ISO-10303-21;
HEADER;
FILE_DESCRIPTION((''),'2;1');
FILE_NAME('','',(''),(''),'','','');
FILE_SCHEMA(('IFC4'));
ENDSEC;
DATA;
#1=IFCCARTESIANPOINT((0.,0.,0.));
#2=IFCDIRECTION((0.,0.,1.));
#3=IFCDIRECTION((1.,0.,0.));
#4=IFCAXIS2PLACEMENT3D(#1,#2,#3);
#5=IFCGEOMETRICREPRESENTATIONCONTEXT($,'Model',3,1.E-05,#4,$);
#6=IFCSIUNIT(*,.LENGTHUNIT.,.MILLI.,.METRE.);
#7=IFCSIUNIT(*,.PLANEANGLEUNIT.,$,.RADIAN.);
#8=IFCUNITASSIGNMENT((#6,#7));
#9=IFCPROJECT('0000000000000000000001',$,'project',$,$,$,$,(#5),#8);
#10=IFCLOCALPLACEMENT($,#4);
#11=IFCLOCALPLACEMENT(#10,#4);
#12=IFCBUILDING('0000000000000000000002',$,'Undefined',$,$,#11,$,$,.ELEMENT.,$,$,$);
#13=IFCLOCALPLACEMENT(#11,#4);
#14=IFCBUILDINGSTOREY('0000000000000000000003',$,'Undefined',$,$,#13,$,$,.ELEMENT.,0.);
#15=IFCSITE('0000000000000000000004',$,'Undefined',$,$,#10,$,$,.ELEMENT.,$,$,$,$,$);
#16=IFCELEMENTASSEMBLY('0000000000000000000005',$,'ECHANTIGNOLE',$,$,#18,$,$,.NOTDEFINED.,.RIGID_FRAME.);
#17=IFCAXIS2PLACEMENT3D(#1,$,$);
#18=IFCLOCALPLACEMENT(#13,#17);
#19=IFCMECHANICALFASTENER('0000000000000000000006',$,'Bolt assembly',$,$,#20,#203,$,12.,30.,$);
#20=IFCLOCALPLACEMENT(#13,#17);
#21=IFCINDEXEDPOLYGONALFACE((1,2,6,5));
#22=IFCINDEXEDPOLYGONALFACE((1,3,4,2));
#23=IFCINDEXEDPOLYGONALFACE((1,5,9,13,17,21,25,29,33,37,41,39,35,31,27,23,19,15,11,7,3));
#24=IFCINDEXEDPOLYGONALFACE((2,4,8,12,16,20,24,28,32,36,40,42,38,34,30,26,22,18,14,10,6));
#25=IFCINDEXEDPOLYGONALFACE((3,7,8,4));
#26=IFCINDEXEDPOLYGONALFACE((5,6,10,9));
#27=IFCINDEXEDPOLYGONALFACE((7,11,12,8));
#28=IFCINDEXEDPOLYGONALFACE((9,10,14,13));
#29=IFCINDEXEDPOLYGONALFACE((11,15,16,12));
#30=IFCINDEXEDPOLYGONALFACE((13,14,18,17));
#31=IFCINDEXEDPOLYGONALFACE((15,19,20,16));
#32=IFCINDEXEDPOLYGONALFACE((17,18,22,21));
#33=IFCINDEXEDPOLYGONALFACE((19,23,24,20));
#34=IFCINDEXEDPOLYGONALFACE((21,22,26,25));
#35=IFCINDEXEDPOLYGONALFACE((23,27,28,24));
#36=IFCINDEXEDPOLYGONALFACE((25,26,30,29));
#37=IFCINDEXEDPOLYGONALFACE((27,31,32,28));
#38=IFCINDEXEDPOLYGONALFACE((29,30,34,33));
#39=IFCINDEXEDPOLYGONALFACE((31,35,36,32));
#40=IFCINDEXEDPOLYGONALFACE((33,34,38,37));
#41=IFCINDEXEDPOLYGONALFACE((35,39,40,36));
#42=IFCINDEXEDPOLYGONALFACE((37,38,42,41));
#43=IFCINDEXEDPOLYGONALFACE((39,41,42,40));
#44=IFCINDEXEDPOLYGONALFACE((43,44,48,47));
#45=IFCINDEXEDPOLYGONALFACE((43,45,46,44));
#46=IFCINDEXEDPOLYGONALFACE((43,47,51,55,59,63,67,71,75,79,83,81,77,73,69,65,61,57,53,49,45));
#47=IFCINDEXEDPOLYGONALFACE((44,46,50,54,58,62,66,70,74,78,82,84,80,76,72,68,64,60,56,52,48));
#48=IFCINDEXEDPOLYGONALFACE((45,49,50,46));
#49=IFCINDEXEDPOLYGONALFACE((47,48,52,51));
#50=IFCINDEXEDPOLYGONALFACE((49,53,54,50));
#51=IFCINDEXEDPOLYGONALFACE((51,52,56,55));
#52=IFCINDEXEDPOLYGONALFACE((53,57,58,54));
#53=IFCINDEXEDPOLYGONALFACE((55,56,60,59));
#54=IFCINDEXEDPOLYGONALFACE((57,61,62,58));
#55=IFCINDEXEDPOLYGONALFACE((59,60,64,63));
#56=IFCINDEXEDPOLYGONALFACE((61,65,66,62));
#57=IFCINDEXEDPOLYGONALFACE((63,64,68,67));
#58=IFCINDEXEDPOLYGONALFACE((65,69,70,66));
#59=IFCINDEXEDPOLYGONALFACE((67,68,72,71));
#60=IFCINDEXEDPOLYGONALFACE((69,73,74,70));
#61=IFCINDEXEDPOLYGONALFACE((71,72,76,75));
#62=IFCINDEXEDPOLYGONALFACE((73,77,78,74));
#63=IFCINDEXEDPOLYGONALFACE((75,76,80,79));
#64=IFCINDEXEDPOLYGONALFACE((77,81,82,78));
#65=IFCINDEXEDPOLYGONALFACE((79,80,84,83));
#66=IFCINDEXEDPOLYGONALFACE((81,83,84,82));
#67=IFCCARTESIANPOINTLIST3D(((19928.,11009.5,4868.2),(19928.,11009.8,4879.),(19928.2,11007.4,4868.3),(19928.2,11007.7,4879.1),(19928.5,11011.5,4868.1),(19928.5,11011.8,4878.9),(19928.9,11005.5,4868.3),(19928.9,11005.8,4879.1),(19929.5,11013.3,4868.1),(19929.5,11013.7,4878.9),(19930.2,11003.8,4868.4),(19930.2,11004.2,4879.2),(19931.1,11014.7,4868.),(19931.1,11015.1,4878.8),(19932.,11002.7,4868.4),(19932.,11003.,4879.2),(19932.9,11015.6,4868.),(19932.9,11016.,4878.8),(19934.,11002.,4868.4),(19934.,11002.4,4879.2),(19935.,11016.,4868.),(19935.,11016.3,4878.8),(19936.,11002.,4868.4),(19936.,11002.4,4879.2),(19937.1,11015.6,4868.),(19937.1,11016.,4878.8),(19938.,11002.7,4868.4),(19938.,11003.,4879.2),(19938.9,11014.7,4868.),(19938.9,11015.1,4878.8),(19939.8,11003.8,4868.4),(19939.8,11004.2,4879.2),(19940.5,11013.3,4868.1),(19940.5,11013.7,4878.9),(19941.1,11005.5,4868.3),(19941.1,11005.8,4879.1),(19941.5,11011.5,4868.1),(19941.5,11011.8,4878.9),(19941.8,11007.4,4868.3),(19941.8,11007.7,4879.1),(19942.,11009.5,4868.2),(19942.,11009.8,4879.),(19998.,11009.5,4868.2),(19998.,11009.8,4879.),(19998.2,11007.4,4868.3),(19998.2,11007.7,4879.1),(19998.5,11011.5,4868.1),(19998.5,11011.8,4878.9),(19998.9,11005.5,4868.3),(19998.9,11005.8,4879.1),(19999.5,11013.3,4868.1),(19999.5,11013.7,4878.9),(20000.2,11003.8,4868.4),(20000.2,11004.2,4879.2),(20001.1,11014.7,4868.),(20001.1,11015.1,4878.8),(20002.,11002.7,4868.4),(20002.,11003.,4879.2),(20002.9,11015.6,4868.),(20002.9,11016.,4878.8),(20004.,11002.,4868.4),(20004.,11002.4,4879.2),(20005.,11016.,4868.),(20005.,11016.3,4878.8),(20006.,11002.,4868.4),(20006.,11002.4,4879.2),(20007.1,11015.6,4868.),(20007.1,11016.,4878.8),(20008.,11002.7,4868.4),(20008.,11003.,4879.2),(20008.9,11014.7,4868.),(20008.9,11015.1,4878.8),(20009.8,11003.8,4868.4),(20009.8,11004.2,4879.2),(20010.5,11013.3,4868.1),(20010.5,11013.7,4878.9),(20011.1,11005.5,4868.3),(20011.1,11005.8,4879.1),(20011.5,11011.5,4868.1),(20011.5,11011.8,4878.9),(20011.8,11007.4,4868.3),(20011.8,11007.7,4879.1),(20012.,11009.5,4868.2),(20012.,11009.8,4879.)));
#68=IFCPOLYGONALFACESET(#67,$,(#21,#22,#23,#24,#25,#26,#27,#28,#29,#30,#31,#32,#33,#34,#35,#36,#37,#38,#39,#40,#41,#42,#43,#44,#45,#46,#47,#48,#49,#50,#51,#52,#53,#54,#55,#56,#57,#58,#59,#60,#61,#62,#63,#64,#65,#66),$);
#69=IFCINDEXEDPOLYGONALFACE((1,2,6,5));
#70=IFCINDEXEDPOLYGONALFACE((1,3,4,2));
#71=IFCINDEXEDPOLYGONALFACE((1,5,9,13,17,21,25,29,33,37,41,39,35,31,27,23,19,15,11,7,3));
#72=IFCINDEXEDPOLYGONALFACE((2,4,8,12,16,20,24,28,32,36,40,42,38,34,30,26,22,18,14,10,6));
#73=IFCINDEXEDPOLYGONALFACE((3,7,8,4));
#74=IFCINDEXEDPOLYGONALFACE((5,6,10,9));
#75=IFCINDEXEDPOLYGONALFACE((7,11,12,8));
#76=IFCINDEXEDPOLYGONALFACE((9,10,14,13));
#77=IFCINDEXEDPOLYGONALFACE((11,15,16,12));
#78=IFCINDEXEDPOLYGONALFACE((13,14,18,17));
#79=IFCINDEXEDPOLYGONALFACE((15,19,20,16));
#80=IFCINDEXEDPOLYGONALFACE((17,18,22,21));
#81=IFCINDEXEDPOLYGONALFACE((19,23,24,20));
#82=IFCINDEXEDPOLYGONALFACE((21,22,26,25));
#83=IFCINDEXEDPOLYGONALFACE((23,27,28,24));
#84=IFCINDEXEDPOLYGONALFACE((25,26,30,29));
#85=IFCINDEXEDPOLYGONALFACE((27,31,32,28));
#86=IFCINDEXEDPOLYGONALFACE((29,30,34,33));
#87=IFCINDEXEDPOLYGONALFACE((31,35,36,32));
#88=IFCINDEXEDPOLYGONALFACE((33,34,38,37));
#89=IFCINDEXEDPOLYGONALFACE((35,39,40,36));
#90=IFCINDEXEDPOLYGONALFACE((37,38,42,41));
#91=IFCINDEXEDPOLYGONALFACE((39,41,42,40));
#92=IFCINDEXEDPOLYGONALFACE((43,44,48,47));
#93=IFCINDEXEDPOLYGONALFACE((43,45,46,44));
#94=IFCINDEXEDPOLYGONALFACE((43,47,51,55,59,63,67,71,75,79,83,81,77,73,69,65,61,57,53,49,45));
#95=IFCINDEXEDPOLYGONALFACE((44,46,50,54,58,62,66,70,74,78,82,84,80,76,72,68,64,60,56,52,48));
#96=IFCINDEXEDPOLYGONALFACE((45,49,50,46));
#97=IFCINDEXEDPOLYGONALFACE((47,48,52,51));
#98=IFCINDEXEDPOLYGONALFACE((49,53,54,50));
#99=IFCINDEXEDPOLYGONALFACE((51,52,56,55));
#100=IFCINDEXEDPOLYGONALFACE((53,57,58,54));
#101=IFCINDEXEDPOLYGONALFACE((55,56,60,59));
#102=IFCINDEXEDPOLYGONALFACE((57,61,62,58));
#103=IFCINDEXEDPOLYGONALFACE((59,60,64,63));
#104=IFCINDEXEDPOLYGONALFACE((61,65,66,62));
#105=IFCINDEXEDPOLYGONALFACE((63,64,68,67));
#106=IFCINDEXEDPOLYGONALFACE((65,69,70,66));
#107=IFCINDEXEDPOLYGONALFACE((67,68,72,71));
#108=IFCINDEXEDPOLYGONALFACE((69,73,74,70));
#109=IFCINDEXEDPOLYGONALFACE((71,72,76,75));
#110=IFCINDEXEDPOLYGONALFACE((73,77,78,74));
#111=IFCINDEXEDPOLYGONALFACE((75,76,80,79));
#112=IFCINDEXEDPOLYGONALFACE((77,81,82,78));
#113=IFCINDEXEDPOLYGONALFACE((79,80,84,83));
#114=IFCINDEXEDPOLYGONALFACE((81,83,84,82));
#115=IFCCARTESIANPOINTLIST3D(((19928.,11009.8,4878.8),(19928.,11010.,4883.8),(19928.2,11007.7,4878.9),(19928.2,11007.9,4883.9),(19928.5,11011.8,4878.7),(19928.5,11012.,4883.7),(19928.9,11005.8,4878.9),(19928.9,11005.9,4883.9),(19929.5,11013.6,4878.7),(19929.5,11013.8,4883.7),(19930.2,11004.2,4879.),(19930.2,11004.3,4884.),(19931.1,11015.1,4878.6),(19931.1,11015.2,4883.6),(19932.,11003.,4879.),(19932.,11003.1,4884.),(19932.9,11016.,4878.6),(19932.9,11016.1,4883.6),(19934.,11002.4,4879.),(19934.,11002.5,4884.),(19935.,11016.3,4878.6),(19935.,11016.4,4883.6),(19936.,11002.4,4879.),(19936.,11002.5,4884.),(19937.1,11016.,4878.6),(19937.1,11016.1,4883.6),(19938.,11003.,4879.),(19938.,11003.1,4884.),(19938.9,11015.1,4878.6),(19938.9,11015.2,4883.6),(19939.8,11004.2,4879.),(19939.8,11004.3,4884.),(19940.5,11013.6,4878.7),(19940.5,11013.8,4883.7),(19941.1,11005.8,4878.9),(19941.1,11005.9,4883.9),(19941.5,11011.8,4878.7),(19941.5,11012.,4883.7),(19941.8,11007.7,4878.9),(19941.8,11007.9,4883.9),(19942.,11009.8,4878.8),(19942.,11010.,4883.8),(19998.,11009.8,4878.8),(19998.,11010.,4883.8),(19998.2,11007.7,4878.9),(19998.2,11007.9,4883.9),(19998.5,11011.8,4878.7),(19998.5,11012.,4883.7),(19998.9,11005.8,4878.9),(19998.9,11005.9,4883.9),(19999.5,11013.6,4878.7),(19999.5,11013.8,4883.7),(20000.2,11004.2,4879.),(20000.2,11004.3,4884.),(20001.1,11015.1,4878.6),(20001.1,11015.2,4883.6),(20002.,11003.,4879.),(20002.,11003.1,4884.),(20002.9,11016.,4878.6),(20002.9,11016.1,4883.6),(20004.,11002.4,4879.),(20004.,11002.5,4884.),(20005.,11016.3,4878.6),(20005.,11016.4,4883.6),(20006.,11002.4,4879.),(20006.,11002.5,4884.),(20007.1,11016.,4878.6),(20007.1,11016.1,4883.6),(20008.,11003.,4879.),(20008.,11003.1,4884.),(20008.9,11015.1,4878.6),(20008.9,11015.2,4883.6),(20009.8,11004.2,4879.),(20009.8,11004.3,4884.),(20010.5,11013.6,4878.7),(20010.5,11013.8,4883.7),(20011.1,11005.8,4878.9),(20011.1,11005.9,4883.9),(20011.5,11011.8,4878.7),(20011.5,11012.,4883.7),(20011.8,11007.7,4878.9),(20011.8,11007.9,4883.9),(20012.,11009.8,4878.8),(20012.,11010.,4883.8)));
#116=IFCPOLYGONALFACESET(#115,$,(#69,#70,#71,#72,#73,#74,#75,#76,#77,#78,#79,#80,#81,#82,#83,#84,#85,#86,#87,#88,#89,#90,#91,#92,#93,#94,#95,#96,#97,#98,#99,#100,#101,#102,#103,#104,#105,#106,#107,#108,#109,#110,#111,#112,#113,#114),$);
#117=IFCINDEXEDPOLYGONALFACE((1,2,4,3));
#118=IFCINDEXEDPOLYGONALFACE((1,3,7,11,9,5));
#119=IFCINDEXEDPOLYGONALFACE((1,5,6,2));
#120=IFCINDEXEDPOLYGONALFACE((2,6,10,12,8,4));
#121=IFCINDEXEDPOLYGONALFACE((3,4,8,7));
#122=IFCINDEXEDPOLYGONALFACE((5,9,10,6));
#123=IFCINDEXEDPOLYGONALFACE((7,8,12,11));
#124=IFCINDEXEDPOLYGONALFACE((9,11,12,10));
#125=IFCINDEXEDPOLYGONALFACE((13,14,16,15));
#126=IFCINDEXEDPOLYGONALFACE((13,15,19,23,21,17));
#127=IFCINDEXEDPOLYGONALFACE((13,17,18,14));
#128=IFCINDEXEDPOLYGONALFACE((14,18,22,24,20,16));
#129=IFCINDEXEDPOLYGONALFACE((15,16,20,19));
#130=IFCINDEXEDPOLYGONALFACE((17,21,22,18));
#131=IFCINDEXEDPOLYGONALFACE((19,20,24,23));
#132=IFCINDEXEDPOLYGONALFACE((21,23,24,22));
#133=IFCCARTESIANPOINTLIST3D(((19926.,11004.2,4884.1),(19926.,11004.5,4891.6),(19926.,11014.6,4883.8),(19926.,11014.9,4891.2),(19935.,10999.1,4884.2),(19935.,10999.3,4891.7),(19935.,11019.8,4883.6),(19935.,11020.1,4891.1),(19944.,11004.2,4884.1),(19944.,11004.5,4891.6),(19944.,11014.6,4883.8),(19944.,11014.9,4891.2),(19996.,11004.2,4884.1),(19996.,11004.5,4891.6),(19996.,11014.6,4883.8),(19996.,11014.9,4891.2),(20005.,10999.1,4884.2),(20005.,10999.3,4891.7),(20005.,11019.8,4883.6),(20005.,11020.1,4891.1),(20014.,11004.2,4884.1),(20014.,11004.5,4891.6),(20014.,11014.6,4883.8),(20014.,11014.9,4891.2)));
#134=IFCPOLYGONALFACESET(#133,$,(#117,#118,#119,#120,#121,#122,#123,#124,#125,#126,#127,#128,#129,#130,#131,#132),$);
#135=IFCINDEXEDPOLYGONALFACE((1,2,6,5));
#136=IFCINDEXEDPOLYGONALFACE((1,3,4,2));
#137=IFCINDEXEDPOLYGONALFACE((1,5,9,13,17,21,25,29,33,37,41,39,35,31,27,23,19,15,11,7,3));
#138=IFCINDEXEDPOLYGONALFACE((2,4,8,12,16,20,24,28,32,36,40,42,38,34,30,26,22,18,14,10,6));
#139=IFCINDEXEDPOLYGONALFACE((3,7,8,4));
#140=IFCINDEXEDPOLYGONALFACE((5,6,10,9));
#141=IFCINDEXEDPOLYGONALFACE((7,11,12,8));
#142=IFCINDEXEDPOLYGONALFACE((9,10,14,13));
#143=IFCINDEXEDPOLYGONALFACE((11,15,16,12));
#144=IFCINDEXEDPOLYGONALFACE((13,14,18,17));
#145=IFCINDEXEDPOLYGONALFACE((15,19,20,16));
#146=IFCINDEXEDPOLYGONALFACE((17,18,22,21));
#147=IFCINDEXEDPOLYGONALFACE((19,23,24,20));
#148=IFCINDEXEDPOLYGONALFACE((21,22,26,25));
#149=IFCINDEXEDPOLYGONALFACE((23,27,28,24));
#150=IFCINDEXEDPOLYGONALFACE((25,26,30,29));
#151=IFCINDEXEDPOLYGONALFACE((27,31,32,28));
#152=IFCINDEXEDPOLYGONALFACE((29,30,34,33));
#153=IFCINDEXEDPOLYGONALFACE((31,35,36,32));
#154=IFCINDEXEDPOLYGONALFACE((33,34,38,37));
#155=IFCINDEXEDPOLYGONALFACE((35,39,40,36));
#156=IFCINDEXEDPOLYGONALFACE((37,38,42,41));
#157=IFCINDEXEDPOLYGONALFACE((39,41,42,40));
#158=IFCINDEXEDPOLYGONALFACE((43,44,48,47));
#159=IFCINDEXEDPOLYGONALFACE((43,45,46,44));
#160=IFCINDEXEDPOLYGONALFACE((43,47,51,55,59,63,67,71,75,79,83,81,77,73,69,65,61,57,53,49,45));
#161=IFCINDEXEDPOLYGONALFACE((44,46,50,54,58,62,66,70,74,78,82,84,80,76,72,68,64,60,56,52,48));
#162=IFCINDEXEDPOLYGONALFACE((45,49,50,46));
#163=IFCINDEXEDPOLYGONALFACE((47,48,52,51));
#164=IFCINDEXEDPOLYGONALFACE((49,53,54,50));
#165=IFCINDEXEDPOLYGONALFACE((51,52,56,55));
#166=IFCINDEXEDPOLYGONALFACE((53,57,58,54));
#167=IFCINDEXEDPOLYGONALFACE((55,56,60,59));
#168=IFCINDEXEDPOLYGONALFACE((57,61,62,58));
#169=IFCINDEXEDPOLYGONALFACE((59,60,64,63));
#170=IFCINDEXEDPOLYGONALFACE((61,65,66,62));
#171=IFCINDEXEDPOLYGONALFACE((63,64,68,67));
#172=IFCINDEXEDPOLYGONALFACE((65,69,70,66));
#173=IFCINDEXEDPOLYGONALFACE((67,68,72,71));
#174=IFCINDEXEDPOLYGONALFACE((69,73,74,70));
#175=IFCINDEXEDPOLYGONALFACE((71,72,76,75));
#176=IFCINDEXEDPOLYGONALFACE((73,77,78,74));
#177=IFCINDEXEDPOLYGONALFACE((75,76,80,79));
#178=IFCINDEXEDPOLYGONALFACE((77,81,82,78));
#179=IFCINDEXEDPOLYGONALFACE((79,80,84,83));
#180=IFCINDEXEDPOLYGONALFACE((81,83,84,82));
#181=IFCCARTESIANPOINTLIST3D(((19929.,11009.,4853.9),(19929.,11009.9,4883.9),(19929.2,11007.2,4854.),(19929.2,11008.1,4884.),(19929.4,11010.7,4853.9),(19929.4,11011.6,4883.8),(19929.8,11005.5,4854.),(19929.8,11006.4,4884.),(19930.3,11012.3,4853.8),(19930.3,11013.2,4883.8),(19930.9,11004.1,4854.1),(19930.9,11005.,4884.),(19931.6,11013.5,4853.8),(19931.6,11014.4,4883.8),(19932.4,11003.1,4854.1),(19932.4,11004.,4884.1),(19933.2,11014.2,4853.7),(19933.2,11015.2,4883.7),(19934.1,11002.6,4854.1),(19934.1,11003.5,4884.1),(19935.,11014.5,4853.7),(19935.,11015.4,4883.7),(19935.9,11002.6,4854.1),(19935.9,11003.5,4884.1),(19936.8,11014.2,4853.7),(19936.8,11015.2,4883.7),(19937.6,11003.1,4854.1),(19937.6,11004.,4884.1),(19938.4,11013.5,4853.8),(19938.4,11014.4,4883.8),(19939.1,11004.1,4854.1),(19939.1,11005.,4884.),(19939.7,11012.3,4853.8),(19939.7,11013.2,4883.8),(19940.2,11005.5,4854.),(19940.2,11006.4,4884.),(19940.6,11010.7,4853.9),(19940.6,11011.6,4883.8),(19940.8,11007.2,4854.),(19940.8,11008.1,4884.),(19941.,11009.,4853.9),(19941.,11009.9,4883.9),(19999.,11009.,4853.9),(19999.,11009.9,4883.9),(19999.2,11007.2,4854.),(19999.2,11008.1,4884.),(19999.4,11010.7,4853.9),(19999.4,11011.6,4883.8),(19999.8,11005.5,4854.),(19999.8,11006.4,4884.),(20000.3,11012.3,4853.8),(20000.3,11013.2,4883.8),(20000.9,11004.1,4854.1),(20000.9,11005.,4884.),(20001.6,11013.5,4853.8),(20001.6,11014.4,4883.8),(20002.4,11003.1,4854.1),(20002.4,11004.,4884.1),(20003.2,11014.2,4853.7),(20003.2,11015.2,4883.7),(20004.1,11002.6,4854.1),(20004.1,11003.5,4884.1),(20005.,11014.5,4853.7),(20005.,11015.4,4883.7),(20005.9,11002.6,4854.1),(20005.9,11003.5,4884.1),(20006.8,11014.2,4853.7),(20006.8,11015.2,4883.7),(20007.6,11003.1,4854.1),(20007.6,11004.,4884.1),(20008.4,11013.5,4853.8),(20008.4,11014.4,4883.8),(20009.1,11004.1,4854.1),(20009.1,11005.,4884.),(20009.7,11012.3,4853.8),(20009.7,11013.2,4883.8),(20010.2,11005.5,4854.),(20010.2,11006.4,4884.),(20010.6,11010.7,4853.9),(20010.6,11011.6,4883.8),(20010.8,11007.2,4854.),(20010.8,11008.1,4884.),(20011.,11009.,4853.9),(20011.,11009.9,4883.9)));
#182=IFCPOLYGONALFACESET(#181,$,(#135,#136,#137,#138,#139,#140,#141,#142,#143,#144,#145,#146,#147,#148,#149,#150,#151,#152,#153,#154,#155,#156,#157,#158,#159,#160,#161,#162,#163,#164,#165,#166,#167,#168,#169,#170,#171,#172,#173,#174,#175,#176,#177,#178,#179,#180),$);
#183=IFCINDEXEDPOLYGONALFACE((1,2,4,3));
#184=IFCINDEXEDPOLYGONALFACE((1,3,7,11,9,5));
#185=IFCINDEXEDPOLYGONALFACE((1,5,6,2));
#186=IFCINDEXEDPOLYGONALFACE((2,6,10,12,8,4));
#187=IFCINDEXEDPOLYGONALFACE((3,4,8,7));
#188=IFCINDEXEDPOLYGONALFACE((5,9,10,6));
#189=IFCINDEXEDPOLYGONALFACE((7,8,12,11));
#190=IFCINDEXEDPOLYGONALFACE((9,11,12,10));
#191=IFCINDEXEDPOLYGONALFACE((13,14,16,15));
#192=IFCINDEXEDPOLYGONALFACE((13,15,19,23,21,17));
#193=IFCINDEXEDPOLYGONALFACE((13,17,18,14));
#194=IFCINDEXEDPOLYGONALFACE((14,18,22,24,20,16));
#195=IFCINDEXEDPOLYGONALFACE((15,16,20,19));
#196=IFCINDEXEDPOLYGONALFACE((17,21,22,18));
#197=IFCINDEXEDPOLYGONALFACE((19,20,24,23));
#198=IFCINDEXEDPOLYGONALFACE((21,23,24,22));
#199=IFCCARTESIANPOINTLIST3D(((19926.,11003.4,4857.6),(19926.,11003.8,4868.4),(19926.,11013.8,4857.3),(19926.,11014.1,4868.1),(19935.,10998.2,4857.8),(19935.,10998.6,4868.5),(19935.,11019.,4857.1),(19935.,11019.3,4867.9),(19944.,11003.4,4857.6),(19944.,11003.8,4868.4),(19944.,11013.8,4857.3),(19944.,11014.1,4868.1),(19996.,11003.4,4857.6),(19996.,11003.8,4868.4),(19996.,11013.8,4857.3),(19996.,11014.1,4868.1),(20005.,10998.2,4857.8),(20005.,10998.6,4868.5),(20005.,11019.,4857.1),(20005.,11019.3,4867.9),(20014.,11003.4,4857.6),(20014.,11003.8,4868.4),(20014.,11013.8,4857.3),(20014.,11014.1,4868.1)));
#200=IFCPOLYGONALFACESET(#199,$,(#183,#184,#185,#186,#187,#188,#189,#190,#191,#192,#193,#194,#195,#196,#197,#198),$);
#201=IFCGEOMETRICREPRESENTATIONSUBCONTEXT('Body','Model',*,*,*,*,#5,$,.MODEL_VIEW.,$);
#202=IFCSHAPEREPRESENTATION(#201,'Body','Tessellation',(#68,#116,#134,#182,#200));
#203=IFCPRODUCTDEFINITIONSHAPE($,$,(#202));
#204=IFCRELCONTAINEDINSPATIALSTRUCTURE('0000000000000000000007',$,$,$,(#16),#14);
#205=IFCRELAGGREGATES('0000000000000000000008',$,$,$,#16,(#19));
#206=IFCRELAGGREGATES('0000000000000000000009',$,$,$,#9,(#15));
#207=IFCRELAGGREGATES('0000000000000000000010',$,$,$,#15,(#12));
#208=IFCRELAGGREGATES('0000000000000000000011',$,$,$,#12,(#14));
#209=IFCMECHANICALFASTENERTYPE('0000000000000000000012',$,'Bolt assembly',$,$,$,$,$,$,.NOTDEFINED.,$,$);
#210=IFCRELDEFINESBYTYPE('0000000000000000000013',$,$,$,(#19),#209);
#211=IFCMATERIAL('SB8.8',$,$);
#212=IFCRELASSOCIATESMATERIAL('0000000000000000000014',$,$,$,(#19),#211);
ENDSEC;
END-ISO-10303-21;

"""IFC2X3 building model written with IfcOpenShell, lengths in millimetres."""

from ifc_helpers import new_model, si_unit, frame, origin_with_axes, origin_2d_with_axis, place, context, subcontext, project, spatial, polyline, circle, outline, extrude, source, transform, mapped, material, type_object, element, aggregate, save


model = new_model("IFC2X3")

# Units and contexts
model_context = context("Model", 3, precision=1e-05, world=origin_with_axes())
body_context = subcontext(model_context, "Body", "Model", "MODEL_VIEW")
ifc_project = project(units=[si_unit("LENGTHUNIT", "METRE", prefix="MILLI"), si_unit("PLANEANGLEUNIT", "RADIAN")], contexts=[model_context])

# Site, building, storey
site_placement = place(None, origin_with_axes())
site = spatial("IfcSite", under=ifc_project, at=site_placement, Name="Undefined", CompositionType="ELEMENT")
building_placement = place(site_placement, origin_with_axes())
building = spatial("IfcBuilding", under=site, at=building_placement, Name="Undefined", CompositionType="ELEMENT")
storey_placement = place(building_placement, origin_with_axes())
storey = spatial("IfcBuildingStorey", under=building, at=storey_placement, Name="Undefined", CompositionType="ELEMENT", Elevation=0.0)

# Shared definitions
ifc_material_1 = material(Name="SB8.8")
mechanical_fastener_type = type_object("IfcMechanicalFastenerType", Name="Bolt assembly")

# Element assembly, mechanical fastener
assembly_1_placement = place(storey_placement, origin_with_axes())
assembly_1 = element("IfcElementAssembly", 1, at=assembly_1_placement, inside=storey, Name="ECHANTIGNOLE", AssemblyPlace="NOTDEFINED", PredefinedType="RIGID_FRAME")
shared_shape_1 = source(origin_with_axes(), body_context, "Body", "SweptSolid", [
    extrude(circle(Radius=7.0, at=origin_2d_with_axis()), frame((0.0, -0.1, 0.0), z_axis=(0.0, 1.0, 0.0), x_axis=(1.0, 0.0, 0.0)), (0.0, 0.0, 1.0), 10.8),
    extrude(circle(Radius=7.0, at=origin_2d_with_axis()), frame((0.0, -4.9, 0.0), z_axis=(0.0, 1.0, 0.0), x_axis=(1.0, 0.0, 0.0)), (0.0, 0.0, 1.0), 5.0),
    extrude(outline(polyline([(10.4, 0.0), (5.2, 9.0), (-5.2, 9.0), (-10.4, 0.0), (-5.2, -9.0), (5.2, -9.0), (10.4, 0.0)])), frame((0.0, -12.5, 0.0), z_axis=(0.0, 1.0, 0.0), x_axis=(1.0, 0.0, 0.0)), (0.0, 0.0, 1.0), 7.5),
    extrude(circle(Radius=6.0, at=origin_2d_with_axis()), frame((0.0, -5.0, 0.0), z_axis=(0.0, 1.0, 0.0), x_axis=(1.0, 0.0, 0.0)), (0.0, 0.0, 1.0), 30.0),
    extrude(outline(polyline([(10.4, 0.0), (5.2, 9.0), (-5.2, 9.0), (-10.4, 0.0), (-5.2, -9.0), (5.2, -9.0), (10.4, 0.0)])), frame((0.0, 10.7, 0.0), z_axis=(0.0, 1.0, 0.0), x_axis=(1.0, 0.0, 0.0)), (0.0, 0.0, 1.0), 10.8),
])
mechanical_fastener_1_placement = place(assembly_1_placement, frame((19970.0, 11009.3, 4878.9), z_axis=(-1.0, 0.0, 0.0), x_axis=(0.0, 0.99952, -0.030986)))
mechanical_fastener_1 = element("IfcMechanicalFastener", 2, at=mechanical_fastener_1_placement, type_object=mechanical_fastener_type, material=ifc_material_1, Name="Bolt assembly", NominalDiameter=12.0, NominalLength=30.0, context=body_context, shape_type="MappedRepresentation", body=[
    mapped(shared_shape_1, transform((0.0, 0.0, 35.0))),
    mapped(shared_shape_1, transform((0.0, 0.0, -35.0))),
])
aggregate(assembly_1, [mechanical_fastener_1])

save(model, "model.ifc")
